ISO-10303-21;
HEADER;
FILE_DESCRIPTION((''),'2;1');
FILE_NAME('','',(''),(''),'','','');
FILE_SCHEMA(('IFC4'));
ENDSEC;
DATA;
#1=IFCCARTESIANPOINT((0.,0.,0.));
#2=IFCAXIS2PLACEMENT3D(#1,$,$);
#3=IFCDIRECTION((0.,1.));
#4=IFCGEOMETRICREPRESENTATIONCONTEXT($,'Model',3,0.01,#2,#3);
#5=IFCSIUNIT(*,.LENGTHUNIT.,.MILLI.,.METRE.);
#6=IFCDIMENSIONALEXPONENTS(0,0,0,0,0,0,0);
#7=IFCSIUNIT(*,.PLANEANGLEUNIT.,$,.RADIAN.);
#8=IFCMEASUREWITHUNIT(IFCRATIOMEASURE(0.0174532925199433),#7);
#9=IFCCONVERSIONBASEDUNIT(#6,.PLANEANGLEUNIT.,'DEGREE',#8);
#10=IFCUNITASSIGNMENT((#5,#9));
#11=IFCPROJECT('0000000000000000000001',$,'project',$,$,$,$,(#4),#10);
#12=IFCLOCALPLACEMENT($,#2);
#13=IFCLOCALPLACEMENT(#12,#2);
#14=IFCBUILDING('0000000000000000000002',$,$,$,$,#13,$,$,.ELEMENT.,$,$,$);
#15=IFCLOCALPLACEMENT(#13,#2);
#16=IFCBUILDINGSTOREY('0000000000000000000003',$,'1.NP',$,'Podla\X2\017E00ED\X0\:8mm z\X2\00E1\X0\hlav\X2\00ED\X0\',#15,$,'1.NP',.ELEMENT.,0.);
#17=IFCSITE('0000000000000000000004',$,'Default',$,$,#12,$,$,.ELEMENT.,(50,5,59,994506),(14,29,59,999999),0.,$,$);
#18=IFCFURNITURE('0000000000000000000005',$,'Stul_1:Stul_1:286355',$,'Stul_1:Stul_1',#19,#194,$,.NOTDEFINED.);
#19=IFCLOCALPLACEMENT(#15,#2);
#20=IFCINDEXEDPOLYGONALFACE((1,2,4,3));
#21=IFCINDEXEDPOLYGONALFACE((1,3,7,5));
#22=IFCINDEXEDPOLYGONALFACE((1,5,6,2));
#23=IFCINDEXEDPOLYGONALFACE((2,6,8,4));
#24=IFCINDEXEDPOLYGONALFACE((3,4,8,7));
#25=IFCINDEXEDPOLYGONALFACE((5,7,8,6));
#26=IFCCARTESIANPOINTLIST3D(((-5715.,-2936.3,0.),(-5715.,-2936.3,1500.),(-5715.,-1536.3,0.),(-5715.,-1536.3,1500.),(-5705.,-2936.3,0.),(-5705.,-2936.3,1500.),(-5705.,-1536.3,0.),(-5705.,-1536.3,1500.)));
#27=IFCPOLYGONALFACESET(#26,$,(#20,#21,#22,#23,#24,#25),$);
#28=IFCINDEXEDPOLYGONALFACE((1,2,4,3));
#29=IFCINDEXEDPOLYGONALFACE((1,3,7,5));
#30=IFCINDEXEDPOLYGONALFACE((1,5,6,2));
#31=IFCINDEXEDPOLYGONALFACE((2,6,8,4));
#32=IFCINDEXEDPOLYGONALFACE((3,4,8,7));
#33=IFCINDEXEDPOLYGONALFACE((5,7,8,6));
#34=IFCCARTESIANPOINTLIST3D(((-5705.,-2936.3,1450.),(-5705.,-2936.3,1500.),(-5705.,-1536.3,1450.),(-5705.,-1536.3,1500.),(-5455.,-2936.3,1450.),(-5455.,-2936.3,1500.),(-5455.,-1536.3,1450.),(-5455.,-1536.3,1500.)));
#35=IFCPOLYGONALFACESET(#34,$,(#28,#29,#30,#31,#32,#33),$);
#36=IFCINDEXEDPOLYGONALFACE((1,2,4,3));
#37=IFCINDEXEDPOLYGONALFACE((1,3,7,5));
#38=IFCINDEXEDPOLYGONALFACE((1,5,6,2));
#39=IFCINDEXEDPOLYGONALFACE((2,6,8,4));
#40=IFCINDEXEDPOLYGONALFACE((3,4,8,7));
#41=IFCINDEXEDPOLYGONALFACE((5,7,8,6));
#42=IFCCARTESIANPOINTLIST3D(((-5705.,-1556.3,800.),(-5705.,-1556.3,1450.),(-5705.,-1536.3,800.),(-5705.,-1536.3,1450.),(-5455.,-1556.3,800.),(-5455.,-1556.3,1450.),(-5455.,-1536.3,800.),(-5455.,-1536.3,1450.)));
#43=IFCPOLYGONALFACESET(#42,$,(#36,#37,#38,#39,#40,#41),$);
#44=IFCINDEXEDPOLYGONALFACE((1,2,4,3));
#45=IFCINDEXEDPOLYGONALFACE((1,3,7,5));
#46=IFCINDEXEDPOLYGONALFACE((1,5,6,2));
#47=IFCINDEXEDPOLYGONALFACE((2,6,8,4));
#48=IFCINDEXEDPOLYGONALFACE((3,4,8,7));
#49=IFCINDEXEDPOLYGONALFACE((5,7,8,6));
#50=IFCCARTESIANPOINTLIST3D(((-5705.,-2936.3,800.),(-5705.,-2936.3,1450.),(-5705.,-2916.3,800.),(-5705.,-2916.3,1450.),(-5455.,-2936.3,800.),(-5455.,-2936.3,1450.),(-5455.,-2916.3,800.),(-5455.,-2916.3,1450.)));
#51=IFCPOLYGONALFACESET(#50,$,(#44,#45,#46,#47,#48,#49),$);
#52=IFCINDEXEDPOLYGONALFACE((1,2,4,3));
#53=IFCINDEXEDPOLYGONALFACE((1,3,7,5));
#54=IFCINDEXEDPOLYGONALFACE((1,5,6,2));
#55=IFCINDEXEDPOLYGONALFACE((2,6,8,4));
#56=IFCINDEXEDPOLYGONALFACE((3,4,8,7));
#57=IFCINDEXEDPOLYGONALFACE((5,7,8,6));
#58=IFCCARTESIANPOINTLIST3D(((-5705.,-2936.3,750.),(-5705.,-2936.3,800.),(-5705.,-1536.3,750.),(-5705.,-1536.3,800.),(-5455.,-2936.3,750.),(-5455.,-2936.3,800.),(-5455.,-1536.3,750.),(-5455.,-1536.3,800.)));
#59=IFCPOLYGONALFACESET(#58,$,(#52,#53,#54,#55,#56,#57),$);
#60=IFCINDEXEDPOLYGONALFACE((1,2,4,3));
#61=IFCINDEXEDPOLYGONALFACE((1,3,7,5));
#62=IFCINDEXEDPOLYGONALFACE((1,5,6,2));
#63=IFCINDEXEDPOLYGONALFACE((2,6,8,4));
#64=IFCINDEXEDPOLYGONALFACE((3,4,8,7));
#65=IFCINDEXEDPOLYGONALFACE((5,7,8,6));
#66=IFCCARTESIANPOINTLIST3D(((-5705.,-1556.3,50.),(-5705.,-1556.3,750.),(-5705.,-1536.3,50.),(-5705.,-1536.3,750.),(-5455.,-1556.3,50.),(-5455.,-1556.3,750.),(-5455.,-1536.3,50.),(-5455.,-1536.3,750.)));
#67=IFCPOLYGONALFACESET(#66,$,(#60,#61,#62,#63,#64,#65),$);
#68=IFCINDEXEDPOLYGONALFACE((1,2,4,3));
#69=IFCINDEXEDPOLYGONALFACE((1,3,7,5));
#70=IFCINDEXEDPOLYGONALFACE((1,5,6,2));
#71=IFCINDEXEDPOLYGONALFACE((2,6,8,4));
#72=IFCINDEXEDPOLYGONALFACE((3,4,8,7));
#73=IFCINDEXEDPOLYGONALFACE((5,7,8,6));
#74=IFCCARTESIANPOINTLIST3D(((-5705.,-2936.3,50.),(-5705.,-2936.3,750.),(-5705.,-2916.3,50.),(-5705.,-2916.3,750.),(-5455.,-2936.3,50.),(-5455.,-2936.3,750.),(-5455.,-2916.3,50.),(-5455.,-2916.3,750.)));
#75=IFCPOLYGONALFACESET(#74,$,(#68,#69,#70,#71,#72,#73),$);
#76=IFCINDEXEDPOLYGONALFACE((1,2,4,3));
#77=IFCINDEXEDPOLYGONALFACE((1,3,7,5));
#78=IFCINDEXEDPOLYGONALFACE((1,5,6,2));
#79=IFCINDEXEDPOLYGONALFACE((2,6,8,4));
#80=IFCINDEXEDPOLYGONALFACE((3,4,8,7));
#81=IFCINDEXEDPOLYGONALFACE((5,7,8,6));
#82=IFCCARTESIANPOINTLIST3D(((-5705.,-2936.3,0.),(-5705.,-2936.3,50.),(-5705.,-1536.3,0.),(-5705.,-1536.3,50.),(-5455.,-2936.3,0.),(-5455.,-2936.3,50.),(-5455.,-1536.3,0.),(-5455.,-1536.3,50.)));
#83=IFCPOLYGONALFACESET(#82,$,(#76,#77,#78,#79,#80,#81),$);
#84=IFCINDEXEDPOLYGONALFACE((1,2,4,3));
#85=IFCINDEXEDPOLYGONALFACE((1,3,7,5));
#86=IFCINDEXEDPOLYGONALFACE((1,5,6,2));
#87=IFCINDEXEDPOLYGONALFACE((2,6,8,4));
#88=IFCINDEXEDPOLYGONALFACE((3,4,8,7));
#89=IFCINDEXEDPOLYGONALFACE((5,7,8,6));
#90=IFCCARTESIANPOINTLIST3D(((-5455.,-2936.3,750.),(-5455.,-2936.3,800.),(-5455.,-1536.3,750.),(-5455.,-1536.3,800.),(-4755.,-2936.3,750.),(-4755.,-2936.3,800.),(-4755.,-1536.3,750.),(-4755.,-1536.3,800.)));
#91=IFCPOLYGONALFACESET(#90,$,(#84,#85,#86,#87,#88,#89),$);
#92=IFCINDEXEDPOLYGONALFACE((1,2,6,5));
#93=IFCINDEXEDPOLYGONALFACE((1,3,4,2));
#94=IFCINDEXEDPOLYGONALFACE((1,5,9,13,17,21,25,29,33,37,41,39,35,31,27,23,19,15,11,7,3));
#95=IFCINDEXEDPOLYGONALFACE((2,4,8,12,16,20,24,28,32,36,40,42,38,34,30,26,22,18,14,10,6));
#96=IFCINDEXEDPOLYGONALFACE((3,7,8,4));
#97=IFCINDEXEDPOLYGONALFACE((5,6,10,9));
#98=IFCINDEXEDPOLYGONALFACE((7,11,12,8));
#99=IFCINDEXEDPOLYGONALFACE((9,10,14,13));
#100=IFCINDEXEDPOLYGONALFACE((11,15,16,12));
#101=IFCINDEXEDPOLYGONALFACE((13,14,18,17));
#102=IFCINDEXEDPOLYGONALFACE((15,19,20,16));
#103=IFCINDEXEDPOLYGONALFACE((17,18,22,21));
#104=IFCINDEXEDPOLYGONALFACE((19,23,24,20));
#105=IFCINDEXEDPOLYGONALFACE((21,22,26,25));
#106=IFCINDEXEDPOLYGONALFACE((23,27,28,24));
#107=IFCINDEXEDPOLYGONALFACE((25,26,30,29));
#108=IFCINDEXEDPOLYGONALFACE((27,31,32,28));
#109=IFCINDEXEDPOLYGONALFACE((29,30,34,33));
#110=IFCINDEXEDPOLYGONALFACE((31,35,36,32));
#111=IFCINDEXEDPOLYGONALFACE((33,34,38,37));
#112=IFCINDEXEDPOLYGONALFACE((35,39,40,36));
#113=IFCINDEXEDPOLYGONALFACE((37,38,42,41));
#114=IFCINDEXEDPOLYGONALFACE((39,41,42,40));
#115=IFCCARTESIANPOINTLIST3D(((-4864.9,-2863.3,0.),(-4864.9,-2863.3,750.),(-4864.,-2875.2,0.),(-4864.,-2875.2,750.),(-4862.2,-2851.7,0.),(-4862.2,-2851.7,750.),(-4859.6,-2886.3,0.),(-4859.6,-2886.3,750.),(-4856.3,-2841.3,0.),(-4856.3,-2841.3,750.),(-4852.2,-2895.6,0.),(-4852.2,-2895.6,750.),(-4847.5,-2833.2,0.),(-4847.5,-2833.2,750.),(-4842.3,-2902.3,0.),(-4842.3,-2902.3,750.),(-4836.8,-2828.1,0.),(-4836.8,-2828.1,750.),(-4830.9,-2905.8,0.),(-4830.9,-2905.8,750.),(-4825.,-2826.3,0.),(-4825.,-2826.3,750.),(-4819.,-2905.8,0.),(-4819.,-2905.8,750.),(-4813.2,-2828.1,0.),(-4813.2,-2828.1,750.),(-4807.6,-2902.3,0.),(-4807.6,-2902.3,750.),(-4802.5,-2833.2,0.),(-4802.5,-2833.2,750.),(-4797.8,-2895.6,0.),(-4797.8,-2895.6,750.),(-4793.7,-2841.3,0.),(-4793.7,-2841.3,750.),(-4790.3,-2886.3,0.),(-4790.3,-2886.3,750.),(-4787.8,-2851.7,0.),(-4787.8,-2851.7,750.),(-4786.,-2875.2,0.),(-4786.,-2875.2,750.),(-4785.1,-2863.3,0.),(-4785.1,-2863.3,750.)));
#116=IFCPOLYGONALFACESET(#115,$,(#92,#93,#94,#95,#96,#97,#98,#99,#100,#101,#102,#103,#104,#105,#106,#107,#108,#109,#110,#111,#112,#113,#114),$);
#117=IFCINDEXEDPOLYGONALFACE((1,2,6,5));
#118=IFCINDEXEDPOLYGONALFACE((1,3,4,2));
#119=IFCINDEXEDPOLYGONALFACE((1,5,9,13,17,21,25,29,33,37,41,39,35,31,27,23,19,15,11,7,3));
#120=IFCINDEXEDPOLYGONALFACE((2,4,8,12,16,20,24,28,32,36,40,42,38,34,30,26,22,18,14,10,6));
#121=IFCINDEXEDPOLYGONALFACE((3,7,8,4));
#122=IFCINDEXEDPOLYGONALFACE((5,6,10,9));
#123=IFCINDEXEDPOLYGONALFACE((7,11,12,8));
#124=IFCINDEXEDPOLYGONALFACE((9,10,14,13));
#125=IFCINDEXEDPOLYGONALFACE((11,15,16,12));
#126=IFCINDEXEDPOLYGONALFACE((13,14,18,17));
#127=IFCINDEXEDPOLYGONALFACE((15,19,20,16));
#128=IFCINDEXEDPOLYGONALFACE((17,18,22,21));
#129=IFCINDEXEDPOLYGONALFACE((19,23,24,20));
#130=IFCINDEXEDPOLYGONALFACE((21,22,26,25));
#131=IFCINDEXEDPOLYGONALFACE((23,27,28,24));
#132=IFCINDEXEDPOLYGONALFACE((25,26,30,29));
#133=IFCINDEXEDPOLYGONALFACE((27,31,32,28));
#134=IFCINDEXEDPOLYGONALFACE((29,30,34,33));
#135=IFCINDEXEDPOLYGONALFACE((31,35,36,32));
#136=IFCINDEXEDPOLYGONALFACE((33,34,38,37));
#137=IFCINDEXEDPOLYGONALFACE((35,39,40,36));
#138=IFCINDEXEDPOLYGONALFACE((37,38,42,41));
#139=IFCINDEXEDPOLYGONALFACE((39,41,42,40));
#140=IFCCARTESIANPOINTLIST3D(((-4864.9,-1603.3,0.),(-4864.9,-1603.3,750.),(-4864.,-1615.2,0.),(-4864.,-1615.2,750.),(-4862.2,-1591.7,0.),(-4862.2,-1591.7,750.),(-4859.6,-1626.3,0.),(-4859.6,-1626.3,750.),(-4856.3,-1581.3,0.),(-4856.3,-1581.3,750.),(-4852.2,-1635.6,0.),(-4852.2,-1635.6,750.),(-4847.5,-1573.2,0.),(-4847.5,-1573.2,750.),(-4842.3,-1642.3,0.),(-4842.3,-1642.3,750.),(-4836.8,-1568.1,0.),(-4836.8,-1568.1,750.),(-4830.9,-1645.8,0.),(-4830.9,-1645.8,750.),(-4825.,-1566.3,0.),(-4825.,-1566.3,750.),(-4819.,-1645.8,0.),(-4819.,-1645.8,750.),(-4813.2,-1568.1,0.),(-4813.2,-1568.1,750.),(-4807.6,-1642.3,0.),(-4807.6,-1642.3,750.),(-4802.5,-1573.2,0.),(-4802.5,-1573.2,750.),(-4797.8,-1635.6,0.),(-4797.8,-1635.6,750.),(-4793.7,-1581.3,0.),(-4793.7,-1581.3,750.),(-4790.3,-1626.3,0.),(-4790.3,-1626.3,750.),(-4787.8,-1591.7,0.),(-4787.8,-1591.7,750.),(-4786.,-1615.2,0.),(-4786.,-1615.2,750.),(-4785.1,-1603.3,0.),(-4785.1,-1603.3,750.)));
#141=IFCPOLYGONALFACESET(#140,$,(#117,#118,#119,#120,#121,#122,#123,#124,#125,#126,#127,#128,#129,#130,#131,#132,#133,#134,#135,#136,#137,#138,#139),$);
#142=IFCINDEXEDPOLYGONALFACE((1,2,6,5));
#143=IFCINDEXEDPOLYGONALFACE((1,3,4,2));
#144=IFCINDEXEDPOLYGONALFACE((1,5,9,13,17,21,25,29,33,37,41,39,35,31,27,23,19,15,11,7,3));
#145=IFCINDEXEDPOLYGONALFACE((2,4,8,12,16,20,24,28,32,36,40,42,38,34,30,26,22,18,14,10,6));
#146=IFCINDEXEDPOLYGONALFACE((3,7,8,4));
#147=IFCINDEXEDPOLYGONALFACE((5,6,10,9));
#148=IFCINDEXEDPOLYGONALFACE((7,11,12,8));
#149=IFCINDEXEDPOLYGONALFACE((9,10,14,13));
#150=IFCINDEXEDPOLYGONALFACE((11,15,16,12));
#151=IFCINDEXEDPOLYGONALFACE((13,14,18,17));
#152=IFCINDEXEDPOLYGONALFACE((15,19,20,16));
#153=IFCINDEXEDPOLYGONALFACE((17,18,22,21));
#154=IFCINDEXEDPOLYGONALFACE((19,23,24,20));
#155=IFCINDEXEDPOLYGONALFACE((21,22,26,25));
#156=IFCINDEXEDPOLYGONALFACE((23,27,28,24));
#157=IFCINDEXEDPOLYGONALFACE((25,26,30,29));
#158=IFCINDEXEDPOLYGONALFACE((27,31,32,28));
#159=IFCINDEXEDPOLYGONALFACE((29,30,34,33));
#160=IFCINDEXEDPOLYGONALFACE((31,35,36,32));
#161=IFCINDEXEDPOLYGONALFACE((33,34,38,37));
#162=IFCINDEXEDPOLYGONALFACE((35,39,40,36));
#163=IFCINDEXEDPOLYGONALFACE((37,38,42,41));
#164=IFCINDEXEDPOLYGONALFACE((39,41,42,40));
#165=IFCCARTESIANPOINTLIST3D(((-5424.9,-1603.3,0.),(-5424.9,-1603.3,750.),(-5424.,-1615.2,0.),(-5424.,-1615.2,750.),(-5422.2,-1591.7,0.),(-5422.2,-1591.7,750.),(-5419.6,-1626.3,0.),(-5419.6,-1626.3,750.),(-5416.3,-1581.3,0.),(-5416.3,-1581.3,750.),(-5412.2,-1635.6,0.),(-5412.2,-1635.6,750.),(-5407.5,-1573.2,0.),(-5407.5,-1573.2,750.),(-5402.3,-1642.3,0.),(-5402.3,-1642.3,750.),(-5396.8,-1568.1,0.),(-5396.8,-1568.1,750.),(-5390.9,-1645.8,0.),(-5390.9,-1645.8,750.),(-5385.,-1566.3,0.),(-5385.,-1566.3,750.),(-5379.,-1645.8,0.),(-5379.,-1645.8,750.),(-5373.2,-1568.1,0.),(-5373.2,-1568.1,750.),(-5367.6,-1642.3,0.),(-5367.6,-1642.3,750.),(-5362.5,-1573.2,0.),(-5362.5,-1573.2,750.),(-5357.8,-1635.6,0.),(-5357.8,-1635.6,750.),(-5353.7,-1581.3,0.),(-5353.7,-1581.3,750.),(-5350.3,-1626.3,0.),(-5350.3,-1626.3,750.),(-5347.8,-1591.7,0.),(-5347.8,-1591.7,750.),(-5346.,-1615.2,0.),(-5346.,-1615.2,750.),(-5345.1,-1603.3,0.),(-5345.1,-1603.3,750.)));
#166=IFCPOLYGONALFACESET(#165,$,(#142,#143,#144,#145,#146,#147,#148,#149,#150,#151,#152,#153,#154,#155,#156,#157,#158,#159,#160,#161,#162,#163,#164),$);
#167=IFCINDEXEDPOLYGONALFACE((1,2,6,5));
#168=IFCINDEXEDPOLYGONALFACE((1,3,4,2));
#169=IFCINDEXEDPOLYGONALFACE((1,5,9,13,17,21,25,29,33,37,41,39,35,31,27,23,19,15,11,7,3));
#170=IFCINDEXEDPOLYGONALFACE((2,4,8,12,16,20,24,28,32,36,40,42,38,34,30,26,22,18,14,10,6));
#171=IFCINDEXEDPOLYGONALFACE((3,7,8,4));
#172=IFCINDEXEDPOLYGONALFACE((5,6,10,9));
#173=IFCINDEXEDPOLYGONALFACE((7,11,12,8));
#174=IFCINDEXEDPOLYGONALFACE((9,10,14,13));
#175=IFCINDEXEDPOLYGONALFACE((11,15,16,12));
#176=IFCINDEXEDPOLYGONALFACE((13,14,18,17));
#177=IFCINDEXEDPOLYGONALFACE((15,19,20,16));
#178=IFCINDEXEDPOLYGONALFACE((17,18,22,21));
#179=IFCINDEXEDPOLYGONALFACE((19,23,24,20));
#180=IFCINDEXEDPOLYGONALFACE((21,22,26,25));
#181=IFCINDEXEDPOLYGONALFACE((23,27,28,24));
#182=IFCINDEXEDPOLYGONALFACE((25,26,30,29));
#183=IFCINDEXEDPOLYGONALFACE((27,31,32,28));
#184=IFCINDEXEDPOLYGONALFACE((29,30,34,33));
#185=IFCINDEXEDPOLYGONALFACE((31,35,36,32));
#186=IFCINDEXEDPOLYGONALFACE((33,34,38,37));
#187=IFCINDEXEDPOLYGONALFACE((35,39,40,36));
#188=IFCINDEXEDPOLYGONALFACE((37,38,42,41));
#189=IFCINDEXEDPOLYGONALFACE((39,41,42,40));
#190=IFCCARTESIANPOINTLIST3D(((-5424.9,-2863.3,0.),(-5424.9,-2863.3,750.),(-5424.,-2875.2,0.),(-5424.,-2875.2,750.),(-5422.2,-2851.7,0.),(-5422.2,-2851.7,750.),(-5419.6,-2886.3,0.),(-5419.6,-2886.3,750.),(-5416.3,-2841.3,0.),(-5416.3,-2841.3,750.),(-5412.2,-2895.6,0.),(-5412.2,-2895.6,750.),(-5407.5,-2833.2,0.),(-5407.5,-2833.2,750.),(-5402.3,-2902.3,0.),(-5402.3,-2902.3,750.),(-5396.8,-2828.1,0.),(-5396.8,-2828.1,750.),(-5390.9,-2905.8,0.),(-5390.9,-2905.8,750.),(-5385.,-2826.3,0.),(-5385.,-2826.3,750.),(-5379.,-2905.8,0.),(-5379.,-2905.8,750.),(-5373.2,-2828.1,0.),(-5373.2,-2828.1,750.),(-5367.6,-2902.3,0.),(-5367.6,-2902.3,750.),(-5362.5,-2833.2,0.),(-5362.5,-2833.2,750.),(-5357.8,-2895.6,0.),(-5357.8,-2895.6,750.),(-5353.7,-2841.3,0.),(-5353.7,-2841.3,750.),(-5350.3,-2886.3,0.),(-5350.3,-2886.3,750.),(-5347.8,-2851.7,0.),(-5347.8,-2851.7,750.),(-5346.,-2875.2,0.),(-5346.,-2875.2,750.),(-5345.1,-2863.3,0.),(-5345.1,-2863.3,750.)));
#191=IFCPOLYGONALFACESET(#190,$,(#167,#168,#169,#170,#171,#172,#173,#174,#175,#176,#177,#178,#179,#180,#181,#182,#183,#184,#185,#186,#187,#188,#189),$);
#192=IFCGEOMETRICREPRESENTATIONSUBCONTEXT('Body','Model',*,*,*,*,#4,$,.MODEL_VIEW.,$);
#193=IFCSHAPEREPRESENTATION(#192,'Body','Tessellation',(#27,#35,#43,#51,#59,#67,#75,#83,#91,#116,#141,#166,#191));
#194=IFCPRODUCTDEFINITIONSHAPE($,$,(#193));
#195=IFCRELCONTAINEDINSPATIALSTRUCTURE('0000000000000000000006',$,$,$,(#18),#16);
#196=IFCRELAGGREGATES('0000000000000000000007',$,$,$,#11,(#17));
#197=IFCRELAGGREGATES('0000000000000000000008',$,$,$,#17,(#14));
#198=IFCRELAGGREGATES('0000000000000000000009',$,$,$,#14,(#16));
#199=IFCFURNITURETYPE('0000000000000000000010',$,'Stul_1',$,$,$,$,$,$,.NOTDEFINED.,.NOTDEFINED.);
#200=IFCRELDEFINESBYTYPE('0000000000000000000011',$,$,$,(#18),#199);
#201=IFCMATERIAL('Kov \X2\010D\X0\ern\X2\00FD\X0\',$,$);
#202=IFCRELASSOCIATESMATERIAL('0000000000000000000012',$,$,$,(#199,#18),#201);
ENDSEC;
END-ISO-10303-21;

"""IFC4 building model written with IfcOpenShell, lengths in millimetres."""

from ifc_helpers import new_model, entity, si_unit, converted_unit, direction, frame, frame_2d, origin, origin_2d_with_axis, place, context, subcontext, project, spatial, rectangle, circle, extrude, source, transform, mapped, material, type_object, type_shapes, element, save


model = new_model("IFC4")

# Units and contexts
model_context = context("Model", 3, precision=0.01, world=origin(), true_north=direction((0.0, 1.0)))
body_context = subcontext(model_context, "Body", "Model", "MODEL_VIEW")
ifc_project = project(units=[si_unit("LENGTHUNIT", "METRE", prefix="MILLI"), converted_unit("PLANEANGLEUNIT", "DEGREE", entity("IfcRatioMeasure", 0.0174532925199433), si_unit("PLANEANGLEUNIT", "RADIAN"), dimensions=[0, 0, 0, 0, 0, 0, 0])], contexts=[model_context])

# Site, building, storey
site_placement = place(None, origin())
site = spatial("IfcSite", under=ifc_project, at=site_placement, Name="Default", CompositionType="ELEMENT", RefLatitude=(50, 5, 59, 994506), RefLongitude=(14, 29, 59, 999999), RefElevation=0.0)
building_placement = place(site_placement, origin())
building = spatial("IfcBuilding", under=site, at=building_placement, CompositionType="ELEMENT")
storey_placement = place(building_placement, origin())
storey = spatial("IfcBuildingStorey", under=building, at=storey_placement, Name="1.NP", ObjectType="Podlaží:8mm záhlaví", LongName="1.NP", CompositionType="ELEMENT", Elevation=0.0)

# Furniture
ifc_material_1 = material(Name="Kov černý")
furniture_type = type_object("IfcFurnitureType", Name="Stul_1", AssemblyPlace="NOTDEFINED", PredefinedType="NOTDEFINED", material=ifc_material_1)
shared_shape_1 = source(origin(), body_context, "Body", "SweptSolid", [
    extrude(rectangle(XDim=1400.0, YDim=10.0, at=origin_2d_with_axis()), frame((0.0, 605.0, 0.0), z_axis=(0.0, 0.0, 1.0), x_axis=(-1.0, 0.0, 0.0)), (0.0, 0.0, 1.0), 1500.0),
    extrude(rectangle(XDim=1400.0, YDim=250.0, at=frame_2d((0.0, 0.0), x_axis=(1.0, 0.0))), frame((0.0, 475.0, 1450.0), z_axis=(0.0, 0.0, 1.0), x_axis=(-1.0, 0.0, 0.0)), (0.0, 0.0, 1.0), 50.0),
    extrude(rectangle(XDim=20.0, YDim=250.0, at=origin_2d_with_axis()), frame((690.0, 475.0, 800.0), z_axis=(0.0, 0.0, 1.0), x_axis=(-1.0, 0.0, 0.0)), (0.0, 0.0, 1.0), 650.0),
    extrude(rectangle(XDim=20.0, YDim=250.0, at=frame_2d((0.0, 0.0), x_axis=(1.0, 0.0))), frame((-690.0, 475.0, 800.0), z_axis=(0.0, 0.0, 1.0), x_axis=(-1.0, 0.0, 0.0)), (0.0, 0.0, 1.0), 650.0),
    extrude(rectangle(XDim=1400.0, YDim=250.0, at=origin_2d_with_axis()), frame((0.0, 475.0, 750.0), z_axis=(0.0, 0.0, 1.0), x_axis=(-1.0, 0.0, 0.0)), (0.0, 0.0, 1.0), 50.0),
    extrude(rectangle(XDim=20.0, YDim=250.0, at=origin_2d_with_axis()), frame((690.0, 475.0, 50.0), z_axis=(0.0, 0.0, 1.0), x_axis=(-1.0, 0.0, 0.0)), (0.0, 0.0, 1.0), 700.0),
    extrude(rectangle(XDim=20.0, YDim=250.0, at=frame_2d((0.0, 0.0), x_axis=(1.0, 0.0))), frame((-690.0, 475.0, 50.0), z_axis=(0.0, 0.0, 1.0), x_axis=(-1.0, 0.0, 0.0)), (0.0, 0.0, 1.0), 700.0),
    extrude(rectangle(XDim=1400.0, YDim=250.0, at=origin_2d_with_axis()), frame((0.0, 475.0, 0.0), z_axis=(0.0, 0.0, 1.0), x_axis=(-1.0, 0.0, 0.0)), (0.0, 0.0, 1.0), 50.0),
    extrude(rectangle(XDim=1400.0, YDim=700.0, at=origin_2d_with_axis()), frame((0.0, 0.0, 750.0), z_axis=(0.0, 0.0, 1.0), x_axis=(-1.0, 0.0, 0.0)), (0.0, 0.0, 1.0), 50.0),
    extrude(circle(Radius=40.0, at=frame_2d((0.0, 0.0), x_axis=(1.0, 0.0))), frame((-630.0, -280.0, 0.0)), (0.0, 0.0, 1.0), 750.0),
    extrude(circle(Radius=40.0, at=frame_2d((0.0, 0.0), x_axis=(1.0, 0.0))), frame((630.0, -280.0, 0.0)), (0.0, 0.0, 1.0), 750.0),
    extrude(circle(Radius=40.0, at=frame_2d((0.0, 0.0), x_axis=(1.0, 0.0))), frame((630.0, 280.0, 0.0)), (0.0, 0.0, 1.0), 750.0),
    extrude(circle(Radius=40.0, at=frame_2d((0.0, 0.0), x_axis=(1.0, 0.0))), frame((-630.0, 280.0, 0.0)), (0.0, 0.0, 1.0), 750.0),
])
type_shapes(furniture_type, [shared_shape_1])
for number, where, z_axis, x_axis, name in (
    (1, (-5105.0, -2236.3, 0.0), (0.0, 0.0, 1.0), (0.0, 1.0, 0.0), "Stul_1:Stul_1:286355"),
):
    element("IfcFurniture", number, at=place(storey_placement, frame(where, z_axis=z_axis, x_axis=x_axis)), inside=storey, type_object=furniture_type, material=ifc_material_1, Name=name, ObjectType="Stul_1:Stul_1", PredefinedType="NOTDEFINED", context=body_context, shape_type="MappedRepresentation", body=[
        mapped(shared_shape_1, transform((0.0, 0.0, 0.0), scale=1.0)),
    ])

save(model, "model.ifc")
